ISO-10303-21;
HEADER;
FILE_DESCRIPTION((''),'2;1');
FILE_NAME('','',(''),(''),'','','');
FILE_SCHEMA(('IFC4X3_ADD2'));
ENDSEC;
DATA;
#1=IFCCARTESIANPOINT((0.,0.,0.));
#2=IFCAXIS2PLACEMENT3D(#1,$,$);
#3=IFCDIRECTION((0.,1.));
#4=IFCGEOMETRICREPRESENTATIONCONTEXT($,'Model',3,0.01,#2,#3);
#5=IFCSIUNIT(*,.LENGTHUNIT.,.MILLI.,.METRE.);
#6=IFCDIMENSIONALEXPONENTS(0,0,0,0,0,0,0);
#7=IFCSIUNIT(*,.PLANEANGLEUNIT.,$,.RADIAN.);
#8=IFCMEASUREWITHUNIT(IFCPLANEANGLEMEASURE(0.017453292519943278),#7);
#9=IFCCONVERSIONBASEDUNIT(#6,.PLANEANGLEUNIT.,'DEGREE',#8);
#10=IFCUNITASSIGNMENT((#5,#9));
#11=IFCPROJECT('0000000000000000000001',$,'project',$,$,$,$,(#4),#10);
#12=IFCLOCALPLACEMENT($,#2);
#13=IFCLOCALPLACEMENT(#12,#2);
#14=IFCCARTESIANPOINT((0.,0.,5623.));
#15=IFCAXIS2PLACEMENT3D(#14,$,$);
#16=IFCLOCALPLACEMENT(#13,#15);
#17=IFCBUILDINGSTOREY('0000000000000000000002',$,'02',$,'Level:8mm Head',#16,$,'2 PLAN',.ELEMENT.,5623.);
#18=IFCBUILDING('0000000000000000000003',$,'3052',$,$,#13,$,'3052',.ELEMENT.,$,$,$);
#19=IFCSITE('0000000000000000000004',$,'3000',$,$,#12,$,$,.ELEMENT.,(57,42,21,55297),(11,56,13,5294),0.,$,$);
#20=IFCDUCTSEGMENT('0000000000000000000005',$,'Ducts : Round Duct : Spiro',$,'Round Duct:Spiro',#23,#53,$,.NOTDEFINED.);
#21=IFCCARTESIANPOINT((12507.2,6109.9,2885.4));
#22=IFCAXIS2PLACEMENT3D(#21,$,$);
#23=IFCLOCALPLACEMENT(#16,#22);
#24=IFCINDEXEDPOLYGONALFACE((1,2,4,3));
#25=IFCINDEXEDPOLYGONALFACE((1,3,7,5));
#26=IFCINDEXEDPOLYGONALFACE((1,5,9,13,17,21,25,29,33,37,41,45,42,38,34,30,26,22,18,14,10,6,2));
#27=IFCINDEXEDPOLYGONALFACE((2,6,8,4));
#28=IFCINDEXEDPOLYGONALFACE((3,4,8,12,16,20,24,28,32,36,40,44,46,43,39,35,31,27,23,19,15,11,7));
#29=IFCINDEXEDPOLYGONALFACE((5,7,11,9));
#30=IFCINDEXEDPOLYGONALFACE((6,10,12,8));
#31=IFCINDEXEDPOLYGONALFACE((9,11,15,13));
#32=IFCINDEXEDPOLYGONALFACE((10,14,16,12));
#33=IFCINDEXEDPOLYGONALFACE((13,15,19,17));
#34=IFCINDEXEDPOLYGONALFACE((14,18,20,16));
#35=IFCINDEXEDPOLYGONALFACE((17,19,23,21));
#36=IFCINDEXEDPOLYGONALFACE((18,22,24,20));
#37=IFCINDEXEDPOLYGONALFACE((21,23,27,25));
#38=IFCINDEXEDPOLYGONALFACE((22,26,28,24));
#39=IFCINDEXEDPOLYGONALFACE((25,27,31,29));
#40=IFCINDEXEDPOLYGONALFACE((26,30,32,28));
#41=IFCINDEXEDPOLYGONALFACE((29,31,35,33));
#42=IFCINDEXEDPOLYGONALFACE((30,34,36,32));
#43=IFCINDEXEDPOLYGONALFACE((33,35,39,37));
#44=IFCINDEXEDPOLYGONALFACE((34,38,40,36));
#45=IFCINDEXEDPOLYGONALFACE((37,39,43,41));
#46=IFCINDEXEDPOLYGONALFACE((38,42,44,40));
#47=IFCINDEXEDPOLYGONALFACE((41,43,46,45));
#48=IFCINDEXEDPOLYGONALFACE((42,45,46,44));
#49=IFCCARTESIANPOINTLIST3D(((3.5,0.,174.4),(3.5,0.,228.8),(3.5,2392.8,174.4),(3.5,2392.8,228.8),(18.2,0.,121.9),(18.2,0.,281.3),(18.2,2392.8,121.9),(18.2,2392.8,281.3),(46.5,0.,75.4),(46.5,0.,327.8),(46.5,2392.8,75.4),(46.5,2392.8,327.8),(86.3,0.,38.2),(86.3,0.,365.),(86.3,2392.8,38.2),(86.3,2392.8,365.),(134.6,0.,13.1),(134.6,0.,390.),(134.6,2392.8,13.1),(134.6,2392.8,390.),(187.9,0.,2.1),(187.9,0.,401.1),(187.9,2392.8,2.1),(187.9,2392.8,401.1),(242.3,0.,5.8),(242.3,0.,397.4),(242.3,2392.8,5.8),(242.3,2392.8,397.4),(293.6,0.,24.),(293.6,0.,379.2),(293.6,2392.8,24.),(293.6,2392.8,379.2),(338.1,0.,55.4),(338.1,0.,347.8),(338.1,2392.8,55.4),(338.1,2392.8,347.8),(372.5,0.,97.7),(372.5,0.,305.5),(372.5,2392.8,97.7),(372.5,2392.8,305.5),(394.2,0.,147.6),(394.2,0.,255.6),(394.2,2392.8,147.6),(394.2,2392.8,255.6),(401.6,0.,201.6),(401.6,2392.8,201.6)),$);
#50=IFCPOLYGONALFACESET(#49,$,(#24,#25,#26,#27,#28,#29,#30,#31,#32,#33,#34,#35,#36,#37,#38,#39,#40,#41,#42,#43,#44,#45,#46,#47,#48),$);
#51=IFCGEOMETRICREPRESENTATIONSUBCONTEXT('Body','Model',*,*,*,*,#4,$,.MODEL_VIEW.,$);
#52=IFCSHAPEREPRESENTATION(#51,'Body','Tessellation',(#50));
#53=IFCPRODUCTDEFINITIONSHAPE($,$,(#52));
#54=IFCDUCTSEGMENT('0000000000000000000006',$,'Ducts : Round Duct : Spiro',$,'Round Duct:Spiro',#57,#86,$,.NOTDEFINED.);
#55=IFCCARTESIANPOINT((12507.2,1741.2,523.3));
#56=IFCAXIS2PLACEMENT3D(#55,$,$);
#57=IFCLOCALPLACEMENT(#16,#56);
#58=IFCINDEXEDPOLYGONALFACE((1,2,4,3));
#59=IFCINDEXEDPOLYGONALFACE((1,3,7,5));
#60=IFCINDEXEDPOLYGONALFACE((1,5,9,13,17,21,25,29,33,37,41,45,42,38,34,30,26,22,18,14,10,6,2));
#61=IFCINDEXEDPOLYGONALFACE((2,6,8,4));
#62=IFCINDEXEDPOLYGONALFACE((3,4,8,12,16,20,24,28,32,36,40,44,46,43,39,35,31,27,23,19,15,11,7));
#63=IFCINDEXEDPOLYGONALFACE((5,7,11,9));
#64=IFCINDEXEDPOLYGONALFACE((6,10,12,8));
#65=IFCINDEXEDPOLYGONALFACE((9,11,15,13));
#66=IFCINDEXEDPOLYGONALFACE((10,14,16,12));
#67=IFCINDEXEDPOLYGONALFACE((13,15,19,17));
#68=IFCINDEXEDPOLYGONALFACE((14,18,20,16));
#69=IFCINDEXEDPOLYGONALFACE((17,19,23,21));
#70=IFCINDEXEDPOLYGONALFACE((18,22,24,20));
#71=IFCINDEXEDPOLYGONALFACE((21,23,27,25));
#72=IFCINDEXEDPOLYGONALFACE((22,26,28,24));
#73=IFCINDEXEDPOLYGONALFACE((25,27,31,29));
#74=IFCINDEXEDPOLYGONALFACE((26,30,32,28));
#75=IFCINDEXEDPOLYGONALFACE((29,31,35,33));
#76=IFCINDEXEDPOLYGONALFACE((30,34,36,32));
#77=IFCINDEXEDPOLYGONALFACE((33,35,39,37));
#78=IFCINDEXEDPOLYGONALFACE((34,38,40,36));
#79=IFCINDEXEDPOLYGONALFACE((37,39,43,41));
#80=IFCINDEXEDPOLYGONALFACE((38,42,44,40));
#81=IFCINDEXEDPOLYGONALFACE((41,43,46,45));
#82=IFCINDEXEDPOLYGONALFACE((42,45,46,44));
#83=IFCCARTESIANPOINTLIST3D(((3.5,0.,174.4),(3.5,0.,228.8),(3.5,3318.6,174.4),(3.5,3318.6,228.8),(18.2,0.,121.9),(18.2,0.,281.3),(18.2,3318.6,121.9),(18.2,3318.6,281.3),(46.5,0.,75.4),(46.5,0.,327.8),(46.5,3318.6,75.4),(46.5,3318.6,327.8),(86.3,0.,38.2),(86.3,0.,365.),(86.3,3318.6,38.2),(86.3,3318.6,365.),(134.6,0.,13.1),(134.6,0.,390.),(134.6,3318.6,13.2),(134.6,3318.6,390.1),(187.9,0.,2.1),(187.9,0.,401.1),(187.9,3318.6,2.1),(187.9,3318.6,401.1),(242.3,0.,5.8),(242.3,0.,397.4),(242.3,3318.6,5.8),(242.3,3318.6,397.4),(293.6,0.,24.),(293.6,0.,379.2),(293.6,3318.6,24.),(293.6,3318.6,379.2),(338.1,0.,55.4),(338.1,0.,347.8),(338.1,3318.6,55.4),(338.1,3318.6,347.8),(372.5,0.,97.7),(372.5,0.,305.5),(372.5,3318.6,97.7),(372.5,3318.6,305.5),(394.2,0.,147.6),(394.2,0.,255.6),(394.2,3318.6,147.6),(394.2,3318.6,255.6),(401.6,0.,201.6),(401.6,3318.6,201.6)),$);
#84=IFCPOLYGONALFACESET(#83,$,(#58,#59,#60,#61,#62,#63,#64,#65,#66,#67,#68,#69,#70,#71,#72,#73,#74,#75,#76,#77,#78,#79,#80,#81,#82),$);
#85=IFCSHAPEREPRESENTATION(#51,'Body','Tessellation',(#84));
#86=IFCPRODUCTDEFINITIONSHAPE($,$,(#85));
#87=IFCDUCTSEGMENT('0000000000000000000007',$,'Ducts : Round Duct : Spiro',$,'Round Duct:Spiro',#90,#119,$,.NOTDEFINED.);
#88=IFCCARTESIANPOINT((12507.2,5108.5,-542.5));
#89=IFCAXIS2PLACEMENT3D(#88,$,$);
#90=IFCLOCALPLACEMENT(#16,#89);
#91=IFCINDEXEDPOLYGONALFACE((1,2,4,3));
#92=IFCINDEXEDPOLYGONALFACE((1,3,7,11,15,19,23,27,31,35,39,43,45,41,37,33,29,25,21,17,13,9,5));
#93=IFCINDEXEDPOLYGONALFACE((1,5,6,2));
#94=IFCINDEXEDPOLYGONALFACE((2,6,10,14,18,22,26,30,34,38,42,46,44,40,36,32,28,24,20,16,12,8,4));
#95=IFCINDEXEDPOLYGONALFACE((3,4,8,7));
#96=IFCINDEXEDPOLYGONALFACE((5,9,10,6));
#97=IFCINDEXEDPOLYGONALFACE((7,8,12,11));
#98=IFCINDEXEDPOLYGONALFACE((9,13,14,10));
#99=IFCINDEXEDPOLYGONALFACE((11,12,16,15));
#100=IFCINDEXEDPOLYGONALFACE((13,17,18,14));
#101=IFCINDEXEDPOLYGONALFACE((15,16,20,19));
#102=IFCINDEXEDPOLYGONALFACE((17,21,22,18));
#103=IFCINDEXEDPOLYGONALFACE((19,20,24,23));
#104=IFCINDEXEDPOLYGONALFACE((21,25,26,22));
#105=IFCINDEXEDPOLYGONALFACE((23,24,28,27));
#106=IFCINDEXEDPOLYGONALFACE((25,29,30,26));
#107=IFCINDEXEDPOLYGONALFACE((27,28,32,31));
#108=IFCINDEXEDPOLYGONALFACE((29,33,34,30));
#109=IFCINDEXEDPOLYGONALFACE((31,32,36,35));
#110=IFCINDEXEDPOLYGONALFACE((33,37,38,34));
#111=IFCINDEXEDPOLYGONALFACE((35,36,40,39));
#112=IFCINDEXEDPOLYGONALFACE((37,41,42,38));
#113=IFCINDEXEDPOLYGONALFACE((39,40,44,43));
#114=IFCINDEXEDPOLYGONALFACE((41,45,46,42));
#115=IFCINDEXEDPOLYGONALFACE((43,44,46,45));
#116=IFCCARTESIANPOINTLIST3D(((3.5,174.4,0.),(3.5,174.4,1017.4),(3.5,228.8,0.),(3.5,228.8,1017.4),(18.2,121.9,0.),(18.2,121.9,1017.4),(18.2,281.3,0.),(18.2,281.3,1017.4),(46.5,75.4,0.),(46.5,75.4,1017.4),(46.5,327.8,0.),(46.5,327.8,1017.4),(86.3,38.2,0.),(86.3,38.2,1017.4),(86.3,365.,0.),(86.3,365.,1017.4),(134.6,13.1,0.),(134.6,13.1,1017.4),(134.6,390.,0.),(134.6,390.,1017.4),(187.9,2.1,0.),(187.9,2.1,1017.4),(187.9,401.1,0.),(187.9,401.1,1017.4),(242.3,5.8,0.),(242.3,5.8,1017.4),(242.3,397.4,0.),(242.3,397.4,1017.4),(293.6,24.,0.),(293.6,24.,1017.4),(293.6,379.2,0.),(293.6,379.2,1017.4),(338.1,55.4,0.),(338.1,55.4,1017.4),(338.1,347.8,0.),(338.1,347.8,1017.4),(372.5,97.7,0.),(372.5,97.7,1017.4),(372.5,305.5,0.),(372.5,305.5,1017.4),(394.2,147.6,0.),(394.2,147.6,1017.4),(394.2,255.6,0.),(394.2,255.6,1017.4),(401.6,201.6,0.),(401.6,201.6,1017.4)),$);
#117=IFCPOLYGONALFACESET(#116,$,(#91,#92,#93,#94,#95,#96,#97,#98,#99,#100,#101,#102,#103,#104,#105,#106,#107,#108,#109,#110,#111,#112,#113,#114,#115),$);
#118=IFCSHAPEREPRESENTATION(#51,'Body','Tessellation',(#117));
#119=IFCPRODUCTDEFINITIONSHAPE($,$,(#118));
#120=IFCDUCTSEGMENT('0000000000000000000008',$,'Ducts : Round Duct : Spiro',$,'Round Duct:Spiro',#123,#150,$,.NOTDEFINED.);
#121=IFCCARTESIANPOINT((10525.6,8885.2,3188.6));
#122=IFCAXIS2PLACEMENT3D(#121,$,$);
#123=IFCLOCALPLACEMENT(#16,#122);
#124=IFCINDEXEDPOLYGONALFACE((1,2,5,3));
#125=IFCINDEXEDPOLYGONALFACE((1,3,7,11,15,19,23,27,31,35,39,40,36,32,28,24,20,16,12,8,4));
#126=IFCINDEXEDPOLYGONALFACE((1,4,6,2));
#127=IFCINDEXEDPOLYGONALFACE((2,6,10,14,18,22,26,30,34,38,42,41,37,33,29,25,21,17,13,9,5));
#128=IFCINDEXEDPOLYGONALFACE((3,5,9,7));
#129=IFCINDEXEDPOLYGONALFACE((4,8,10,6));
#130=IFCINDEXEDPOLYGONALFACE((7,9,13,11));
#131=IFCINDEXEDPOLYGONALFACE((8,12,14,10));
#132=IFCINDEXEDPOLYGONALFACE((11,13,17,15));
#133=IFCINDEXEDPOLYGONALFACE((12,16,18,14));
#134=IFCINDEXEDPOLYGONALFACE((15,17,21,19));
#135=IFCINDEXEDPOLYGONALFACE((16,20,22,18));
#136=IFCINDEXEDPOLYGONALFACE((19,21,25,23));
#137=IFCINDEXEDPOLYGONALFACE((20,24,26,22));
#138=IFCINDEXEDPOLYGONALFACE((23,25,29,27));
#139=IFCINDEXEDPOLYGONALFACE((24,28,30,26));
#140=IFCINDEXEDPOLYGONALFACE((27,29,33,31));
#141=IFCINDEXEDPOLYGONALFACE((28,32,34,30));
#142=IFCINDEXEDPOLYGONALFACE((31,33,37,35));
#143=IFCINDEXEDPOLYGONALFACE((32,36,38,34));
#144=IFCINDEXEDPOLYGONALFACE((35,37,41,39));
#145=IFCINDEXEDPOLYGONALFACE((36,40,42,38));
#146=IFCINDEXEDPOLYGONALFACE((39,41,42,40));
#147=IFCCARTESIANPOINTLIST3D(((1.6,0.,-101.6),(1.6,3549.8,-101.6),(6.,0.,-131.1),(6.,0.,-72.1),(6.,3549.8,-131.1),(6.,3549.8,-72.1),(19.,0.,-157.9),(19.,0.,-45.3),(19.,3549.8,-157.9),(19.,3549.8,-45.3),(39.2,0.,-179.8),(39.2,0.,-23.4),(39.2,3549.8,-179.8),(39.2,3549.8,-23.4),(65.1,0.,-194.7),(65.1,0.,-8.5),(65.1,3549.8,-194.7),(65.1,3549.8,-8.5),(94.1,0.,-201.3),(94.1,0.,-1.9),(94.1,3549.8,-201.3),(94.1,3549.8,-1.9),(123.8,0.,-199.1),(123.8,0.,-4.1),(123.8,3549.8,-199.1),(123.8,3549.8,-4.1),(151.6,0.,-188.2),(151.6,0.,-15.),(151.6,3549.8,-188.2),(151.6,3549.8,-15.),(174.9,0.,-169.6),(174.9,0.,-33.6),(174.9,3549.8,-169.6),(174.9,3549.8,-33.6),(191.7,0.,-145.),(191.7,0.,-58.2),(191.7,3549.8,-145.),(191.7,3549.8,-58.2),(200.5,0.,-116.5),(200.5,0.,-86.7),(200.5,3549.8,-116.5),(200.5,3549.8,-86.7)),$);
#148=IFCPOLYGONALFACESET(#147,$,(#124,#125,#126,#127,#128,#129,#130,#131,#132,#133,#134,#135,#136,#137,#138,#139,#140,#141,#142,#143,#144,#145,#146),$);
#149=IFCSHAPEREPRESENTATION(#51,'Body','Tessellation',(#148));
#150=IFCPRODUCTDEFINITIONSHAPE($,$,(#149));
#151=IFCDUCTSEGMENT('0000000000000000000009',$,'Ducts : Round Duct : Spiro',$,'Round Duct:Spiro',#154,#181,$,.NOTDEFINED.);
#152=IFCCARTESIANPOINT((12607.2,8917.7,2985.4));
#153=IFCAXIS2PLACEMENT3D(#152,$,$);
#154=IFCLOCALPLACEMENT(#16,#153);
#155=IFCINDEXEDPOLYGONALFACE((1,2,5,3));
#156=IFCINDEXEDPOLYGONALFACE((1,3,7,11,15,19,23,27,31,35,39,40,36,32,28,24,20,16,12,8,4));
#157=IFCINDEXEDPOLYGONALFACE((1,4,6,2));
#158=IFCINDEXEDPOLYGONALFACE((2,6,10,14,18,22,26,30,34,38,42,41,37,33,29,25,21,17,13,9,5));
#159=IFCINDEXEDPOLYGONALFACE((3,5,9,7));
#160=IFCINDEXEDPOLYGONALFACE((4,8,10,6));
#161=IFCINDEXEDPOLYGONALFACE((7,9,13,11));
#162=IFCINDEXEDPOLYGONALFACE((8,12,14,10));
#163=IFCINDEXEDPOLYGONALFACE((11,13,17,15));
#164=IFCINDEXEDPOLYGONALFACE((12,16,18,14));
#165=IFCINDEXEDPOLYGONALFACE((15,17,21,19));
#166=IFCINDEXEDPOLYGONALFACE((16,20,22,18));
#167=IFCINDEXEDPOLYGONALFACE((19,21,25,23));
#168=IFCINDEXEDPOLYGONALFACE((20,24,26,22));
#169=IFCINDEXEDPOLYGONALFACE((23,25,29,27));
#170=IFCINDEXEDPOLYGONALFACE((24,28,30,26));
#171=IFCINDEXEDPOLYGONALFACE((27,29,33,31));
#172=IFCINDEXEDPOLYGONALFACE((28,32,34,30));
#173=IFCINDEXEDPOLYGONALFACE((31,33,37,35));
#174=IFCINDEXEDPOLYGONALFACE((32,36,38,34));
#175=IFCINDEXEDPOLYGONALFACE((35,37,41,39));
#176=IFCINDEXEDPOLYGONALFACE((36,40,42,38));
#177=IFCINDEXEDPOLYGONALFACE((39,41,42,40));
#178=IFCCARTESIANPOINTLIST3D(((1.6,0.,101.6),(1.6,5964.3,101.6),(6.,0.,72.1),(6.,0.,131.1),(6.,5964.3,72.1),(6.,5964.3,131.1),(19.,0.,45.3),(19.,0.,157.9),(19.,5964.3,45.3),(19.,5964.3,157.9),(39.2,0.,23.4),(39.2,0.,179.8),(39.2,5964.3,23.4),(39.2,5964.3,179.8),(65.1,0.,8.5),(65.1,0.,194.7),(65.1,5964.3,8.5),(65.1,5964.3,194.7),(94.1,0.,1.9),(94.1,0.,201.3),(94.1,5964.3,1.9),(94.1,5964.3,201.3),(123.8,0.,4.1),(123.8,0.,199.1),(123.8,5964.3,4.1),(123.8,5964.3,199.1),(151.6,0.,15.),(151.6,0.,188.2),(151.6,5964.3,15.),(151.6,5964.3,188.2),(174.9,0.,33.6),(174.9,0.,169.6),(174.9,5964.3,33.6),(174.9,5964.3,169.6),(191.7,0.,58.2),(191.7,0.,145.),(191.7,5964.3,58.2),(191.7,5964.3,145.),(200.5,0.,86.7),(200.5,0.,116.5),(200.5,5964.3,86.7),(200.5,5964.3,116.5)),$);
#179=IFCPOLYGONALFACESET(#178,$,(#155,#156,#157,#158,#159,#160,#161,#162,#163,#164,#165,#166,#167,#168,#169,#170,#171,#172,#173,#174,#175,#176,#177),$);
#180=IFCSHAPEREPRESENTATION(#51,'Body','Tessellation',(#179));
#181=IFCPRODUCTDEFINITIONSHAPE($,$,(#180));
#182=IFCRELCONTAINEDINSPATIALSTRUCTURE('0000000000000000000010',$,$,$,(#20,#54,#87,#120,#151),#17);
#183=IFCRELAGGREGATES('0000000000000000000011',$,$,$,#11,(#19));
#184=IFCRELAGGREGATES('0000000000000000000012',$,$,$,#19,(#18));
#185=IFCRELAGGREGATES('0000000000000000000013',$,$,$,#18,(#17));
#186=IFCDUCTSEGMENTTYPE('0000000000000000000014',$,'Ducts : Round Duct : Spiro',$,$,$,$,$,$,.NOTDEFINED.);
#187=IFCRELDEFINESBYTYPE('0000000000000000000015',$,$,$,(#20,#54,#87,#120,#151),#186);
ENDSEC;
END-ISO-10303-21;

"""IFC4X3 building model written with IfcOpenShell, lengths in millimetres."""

from ifc_helpers import new_model, entity, si_unit, converted_unit, direction, frame, frame_2d, origin, origin_2d_with_axis, place, context, subcontext, project, spatial, circle, extrude, type_object, element, save


model = new_model("IFC4X3")

# Units and contexts
model_context = context("Model", 3, precision=0.01, world=origin(), true_north=direction((0.0, 1.0)))
body_context = subcontext(model_context, "Body", "Model", "MODEL_VIEW")
ifc_project = project(units=[si_unit("LENGTHUNIT", "METRE", prefix="MILLI"), converted_unit("PLANEANGLEUNIT", "DEGREE", entity("IfcPlaneAngleMeasure", 0.017453292519943278), si_unit("PLANEANGLEUNIT", "RADIAN"), dimensions=[0, 0, 0, 0, 0, 0, 0])], contexts=[model_context])

# Site, building, storey
site_placement = place(None, origin())
site = spatial("IfcSite", under=ifc_project, at=site_placement, Name="3000", CompositionType="ELEMENT", RefLatitude=(57, 42, 21, 55297), RefLongitude=(11, 56, 13, 5294), RefElevation=0.0)
building_placement = place(site_placement, origin())
building = spatial("IfcBuilding", under=site, at=building_placement, Name="3052", LongName="3052", CompositionType="ELEMENT")
storey_placement = place(building_placement, frame((0.0, 0.0, 5623.0)))
storey = spatial("IfcBuildingStorey", under=building, at=storey_placement, Name="02", ObjectType="Level:8mm Head", LongName="2 PLAN", CompositionType="ELEMENT", Elevation=5623.0)

# Duct segments
duct_segment_type = type_object("IfcDuctSegmentType", Name="Ducts : Round Duct : Spiro", PredefinedType="NOTDEFINED")
duct_segment_1_placement = place(storey_placement, frame((12507.2, 6109.9, 2885.4)))
element("IfcDuctSegment", 1, at=duct_segment_1_placement, inside=storey, type_object=duct_segment_type, Name="Ducts : Round Duct : Spiro", ObjectType="Round Duct:Spiro", PredefinedType="NOTDEFINED", context=body_context, shape_type="SweptSolid", body=[
    extrude(circle(Radius=200.0, at=origin_2d_with_axis()), frame((201.6, 0.0, 201.6), z_axis=(0.0, 1.0, 0.0), x_axis=(1.0, 0.0, 0.0)), (0.0, 0.0, 1.0), 2392.8),
])
duct_segment_2_placement = place(storey_placement, frame((12507.2, 1741.2, 523.3)))
element("IfcDuctSegment", 2, at=duct_segment_2_placement, inside=storey, type_object=duct_segment_type, Name="Ducts : Round Duct : Spiro", ObjectType="Round Duct:Spiro", PredefinedType="NOTDEFINED", context=body_context, shape_type="SweptSolid", body=[
    extrude(circle(Radius=200.0, at=frame_2d((0.0, 0.0), x_axis=(1.0, 0.0))), frame((201.6, 0.0, 201.6), z_axis=(0.0, 1.0, 0.000003), x_axis=(1.0, 0.0, 0.0)), (0.0, 0.0, 1.0), 3318.6),
])
duct_segment_3_placement = place(storey_placement, frame((12507.2, 5108.5, -542.5)))
element("IfcDuctSegment", 3, at=duct_segment_3_placement, inside=storey, type_object=duct_segment_type, Name="Ducts : Round Duct : Spiro", ObjectType="Round Duct:Spiro", PredefinedType="NOTDEFINED", context=body_context, shape_type="SweptSolid", body=[
    extrude(circle(Radius=200.0, at=origin_2d_with_axis()), frame((201.6, 201.6, 0.0)), (0.0, 0.0, 1.0), 1017.4),
])
duct_segment_4_placement = place(storey_placement, frame((10525.6, 8885.2, 3188.6)))
element("IfcDuctSegment", 4, at=duct_segment_4_placement, inside=storey, type_object=duct_segment_type, Name="Ducts : Round Duct : Spiro", ObjectType="Round Duct:Spiro", PredefinedType="NOTDEFINED", context=body_context, shape_type="SweptSolid", body=[
    extrude(circle(Radius=100.0, at=frame_2d((0.0, 0.0), x_axis=(1.0, 0.0))), frame((101.6, 0.0, -101.6), z_axis=(0.0, 1.0, 0.0), x_axis=(-1.0, 0.0, 0.0)), (0.0, 0.0, 1.0), 3549.8),
])
duct_segment_5_placement = place(storey_placement, frame((12607.2, 8917.7, 2985.4)))
element("IfcDuctSegment", 5, at=duct_segment_5_placement, inside=storey, type_object=duct_segment_type, Name="Ducts : Round Duct : Spiro", ObjectType="Round Duct:Spiro", PredefinedType="NOTDEFINED", context=body_context, shape_type="SweptSolid", body=[
    extrude(circle(Radius=100.0, at=frame_2d((0.0, 0.0), x_axis=(1.0, 0.0))), frame((101.6, 0.0, 101.6), z_axis=(0.0, 1.0, 0.0), x_axis=(-1.0, 0.0, 0.0)), (0.0, 0.0, 1.0), 5964.3),
])

save(model, "model.ifc")
